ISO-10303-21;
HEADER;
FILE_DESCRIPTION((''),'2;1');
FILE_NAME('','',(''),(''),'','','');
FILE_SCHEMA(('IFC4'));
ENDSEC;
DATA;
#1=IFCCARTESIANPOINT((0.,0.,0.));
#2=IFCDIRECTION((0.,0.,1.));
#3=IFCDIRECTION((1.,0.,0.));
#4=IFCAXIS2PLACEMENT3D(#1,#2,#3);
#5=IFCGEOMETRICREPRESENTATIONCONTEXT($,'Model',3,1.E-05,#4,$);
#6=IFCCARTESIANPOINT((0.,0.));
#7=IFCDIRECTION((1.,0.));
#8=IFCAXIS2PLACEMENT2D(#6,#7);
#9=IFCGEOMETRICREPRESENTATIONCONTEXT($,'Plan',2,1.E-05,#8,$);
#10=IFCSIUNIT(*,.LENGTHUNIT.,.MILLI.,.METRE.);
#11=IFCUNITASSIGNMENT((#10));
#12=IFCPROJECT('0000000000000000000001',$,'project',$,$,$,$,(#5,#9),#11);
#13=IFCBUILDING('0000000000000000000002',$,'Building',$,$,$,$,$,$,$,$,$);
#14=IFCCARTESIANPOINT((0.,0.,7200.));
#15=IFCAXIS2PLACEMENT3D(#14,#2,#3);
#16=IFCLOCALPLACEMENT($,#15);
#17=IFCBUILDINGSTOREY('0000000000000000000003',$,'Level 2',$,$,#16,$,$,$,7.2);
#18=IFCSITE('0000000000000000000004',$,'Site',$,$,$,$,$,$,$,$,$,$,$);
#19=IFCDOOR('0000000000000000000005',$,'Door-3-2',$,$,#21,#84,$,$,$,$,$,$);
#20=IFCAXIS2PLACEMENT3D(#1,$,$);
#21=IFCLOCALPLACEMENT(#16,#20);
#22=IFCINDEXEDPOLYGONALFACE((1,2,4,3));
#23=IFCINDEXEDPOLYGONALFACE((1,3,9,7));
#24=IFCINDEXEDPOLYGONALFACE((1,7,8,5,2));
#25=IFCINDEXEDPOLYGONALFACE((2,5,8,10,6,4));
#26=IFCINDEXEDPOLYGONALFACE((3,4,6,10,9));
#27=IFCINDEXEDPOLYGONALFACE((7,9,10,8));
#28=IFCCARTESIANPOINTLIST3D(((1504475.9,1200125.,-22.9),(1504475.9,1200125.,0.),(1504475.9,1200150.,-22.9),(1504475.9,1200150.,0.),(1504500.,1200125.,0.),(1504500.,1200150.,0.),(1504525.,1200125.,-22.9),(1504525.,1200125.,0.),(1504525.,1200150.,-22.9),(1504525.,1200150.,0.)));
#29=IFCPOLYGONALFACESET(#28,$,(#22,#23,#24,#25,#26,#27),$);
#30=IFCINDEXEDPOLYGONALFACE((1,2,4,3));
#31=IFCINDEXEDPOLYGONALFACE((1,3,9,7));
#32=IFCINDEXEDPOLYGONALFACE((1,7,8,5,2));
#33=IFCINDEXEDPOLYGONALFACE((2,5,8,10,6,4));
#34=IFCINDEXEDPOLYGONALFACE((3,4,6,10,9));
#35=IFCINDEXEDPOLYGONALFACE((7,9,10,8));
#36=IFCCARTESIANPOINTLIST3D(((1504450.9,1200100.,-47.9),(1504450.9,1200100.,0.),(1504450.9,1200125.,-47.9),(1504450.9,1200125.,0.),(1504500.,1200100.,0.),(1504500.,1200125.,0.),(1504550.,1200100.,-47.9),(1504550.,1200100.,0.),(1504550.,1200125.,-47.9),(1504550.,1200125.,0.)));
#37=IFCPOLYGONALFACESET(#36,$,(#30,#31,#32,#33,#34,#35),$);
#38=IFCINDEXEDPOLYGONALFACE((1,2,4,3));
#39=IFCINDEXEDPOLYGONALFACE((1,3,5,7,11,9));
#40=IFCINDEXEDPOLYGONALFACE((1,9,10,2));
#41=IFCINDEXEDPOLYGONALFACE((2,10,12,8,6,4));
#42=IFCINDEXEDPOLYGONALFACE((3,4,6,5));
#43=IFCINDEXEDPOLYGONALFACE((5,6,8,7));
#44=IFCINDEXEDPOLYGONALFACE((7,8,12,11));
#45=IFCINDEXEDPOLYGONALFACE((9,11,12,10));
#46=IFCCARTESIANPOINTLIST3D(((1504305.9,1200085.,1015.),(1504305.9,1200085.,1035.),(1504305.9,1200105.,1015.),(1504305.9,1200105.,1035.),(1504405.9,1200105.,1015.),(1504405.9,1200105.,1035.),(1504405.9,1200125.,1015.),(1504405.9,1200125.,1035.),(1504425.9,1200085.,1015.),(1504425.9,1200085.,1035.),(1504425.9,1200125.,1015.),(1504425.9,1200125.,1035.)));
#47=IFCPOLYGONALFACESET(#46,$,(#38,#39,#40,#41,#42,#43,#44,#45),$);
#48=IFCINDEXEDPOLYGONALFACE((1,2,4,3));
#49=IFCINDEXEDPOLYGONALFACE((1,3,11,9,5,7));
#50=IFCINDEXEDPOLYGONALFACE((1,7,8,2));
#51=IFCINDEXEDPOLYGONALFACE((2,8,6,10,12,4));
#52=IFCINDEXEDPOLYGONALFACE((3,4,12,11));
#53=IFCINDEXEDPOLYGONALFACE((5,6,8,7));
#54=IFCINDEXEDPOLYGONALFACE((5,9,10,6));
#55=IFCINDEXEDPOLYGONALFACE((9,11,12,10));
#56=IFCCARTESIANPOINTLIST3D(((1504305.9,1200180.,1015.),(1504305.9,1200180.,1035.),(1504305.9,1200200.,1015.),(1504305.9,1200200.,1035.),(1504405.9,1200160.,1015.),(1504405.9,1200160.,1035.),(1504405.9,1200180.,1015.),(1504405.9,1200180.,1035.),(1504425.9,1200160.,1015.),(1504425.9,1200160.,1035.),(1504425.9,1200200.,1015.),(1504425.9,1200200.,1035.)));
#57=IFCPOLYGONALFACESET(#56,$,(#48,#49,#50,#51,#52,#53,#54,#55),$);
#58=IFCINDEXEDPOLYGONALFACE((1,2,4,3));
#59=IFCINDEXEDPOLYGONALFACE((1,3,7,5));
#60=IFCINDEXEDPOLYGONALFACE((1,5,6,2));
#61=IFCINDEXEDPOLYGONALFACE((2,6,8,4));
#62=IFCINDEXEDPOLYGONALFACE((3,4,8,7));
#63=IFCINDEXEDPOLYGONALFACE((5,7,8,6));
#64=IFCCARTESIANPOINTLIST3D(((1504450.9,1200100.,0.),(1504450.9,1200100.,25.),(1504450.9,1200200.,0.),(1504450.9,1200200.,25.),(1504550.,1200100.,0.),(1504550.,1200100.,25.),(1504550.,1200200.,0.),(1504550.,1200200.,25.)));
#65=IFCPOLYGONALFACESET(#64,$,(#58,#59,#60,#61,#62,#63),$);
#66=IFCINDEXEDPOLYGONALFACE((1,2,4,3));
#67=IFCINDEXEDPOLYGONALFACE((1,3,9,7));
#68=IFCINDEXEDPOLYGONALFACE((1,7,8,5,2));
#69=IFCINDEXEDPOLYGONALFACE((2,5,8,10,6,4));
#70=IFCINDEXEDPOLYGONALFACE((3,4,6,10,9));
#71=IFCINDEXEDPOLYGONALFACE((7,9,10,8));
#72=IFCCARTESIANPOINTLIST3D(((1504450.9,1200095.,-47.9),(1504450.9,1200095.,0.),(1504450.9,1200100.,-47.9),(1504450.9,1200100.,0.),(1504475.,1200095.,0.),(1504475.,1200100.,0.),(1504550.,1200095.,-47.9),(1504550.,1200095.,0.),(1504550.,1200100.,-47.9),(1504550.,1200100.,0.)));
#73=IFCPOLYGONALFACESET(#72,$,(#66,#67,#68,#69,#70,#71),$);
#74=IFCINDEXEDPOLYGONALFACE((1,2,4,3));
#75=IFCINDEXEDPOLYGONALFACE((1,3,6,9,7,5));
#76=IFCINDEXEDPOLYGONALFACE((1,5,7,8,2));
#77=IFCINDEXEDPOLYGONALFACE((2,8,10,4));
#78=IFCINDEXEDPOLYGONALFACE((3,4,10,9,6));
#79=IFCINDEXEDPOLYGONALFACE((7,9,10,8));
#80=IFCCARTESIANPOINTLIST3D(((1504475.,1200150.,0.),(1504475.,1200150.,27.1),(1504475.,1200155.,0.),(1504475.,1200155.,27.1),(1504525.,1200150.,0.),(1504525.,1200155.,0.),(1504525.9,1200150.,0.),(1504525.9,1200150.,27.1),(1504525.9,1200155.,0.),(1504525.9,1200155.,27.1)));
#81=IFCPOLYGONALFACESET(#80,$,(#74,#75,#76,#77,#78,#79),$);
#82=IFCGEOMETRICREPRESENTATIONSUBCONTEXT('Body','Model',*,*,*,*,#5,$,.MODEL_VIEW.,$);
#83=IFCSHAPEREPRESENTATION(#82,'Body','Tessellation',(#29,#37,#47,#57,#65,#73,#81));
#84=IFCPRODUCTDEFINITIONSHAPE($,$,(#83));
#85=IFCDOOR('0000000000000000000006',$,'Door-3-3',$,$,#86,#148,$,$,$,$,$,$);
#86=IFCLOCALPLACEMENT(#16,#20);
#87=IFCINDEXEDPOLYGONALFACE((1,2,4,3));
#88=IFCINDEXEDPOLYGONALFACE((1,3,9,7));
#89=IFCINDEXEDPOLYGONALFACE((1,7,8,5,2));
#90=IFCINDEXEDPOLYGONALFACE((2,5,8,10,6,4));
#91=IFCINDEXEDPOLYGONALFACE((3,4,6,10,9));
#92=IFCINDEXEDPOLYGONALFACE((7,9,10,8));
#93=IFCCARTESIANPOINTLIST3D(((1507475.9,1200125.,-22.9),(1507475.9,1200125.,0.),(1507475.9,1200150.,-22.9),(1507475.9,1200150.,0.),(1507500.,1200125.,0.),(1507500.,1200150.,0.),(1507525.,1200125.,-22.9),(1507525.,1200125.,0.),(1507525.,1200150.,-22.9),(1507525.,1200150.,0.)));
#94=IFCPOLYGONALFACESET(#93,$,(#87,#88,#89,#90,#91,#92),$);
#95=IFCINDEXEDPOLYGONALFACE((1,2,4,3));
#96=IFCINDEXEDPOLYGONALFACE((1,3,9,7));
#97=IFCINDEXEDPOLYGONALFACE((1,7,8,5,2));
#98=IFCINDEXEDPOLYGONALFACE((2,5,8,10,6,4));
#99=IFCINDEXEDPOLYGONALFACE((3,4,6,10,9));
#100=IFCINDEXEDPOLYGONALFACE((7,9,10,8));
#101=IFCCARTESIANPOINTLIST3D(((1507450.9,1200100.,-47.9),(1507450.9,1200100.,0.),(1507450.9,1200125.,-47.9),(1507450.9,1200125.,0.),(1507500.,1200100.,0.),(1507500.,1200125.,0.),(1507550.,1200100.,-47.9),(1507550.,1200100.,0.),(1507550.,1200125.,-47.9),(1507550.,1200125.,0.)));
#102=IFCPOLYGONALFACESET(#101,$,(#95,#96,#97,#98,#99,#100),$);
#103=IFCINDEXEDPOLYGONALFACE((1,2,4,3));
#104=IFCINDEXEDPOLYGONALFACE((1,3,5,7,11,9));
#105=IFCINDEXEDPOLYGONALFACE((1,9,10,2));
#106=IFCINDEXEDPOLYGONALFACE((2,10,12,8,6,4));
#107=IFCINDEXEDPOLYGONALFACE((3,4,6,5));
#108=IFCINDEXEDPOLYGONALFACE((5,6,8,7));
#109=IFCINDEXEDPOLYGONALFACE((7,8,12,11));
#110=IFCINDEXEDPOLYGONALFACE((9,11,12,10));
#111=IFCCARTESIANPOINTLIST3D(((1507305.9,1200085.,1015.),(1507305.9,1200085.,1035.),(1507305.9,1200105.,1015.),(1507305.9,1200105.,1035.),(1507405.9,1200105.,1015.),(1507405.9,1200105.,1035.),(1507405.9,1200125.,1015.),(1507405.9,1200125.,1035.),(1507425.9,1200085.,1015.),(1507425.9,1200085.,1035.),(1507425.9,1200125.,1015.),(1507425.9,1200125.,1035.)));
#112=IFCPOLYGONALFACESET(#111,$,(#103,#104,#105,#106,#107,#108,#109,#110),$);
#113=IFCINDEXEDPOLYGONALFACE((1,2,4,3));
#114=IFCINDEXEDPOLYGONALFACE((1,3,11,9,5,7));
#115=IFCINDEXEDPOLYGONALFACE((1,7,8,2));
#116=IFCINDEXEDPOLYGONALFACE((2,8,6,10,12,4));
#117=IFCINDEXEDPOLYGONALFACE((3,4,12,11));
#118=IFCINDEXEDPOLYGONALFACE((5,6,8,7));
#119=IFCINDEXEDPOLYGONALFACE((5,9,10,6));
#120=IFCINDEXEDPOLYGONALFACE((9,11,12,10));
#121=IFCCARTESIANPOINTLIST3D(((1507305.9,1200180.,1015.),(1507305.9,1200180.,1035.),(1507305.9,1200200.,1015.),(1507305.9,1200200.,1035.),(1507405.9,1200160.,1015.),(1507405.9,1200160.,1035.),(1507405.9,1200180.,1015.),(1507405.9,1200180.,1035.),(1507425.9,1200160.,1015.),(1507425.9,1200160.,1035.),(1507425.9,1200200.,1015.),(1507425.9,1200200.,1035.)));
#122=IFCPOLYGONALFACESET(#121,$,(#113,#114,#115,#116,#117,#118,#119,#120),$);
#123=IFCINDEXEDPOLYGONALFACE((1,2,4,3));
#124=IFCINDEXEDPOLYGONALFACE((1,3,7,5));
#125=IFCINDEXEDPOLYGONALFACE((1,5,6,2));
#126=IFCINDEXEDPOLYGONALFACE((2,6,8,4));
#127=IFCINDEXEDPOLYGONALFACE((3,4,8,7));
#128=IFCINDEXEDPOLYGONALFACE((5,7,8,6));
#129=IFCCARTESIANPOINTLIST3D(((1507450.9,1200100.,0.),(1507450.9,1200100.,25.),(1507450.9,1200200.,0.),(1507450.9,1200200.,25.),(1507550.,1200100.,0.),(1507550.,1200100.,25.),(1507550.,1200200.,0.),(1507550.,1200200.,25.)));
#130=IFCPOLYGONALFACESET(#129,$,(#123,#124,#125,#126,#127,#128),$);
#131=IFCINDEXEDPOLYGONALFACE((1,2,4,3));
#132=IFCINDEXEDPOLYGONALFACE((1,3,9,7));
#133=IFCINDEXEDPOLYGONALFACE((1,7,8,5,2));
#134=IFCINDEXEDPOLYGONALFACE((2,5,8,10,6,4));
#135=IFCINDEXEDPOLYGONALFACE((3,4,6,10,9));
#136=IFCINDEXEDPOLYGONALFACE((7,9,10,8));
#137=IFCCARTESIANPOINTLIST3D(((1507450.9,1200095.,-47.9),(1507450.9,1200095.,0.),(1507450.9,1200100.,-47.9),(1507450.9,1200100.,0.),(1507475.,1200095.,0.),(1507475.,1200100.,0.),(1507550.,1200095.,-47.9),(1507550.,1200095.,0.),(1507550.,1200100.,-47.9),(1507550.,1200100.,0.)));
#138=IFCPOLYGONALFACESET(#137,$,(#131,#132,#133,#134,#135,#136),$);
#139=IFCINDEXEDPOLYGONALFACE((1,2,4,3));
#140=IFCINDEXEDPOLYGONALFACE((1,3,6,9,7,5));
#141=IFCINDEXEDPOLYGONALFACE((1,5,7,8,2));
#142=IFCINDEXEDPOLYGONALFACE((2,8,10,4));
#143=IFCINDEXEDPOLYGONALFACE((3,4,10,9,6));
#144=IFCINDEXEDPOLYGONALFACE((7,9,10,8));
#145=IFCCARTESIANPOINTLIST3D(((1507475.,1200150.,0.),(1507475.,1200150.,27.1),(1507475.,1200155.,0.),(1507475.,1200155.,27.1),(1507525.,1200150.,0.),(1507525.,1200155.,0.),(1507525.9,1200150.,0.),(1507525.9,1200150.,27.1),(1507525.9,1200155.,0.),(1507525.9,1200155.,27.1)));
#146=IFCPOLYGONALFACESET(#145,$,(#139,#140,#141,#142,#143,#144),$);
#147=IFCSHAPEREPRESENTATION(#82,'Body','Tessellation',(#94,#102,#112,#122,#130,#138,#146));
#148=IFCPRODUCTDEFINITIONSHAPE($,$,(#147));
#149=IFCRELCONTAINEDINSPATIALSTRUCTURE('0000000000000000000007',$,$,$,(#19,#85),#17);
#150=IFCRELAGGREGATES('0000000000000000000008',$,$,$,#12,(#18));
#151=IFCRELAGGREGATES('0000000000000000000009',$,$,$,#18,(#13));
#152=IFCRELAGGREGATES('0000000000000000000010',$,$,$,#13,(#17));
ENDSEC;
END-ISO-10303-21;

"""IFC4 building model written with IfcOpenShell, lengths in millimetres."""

from ifc_helpers import new_model, si_unit, frame, origin_with_axes, origin_2d_with_axis, place, context, subcontext, project, spatial, line, indexed_curve, outline, extrude, element, save


model = new_model("IFC4")

# Units and contexts
model_context = context("Model", 3, precision=1e-05, world=origin_with_axes())
plan_context = context("Plan", 2, precision=1e-05, world=origin_2d_with_axis())
body_context = subcontext(model_context, "Body", "Model", "MODEL_VIEW")
ifc_project = project(units=[si_unit("LENGTHUNIT", "METRE", prefix="MILLI")], contexts=[model_context, plan_context])

# Site, building, storey
site = spatial("IfcSite", under=ifc_project, Name="Site")
building = spatial("IfcBuilding", under=site, Name="Building")
storey_placement = place(None, frame((0.0, 0.0, 7200.0), z_axis=(0.0, 0.0, 1.0), x_axis=(1.0, 0.0, 0.0)))
storey = spatial("IfcBuildingStorey", under=building, at=storey_placement, Name="Level 2", Elevation=7.2)

# Doors
door_1_placement = place(storey_placement, frame((1504500.0, 1200100.0, 0.0), z_axis=(0.0, 0.0, 1.0), x_axis=(1.0, 0.0, 0.0)))
element("IfcDoor", 1, at=door_1_placement, inside=storey, Name="Door-3-2", context=body_context, shape_type="SweptSolid", body=[
    extrude(outline(indexed_curve([(0.0, 0.0), (0.0, 2.1), (0.9, 2.1), (0.9, 0.0), (-24.1, 0.0), (-24.1, -22.9), (25.0, -22.9), (25.0, 0.0)], segments=[line(1, 2, 3, 4, 5, 6, 7, 8, 1)])), frame((0.0, 25.0, 0.0), z_axis=(0.0, -1.0, 0.0), x_axis=(1.0, 0.0, 0.0)), (0.0, 0.0, -1.0), 25.0),
    extrude(outline(indexed_curve([(0.0, 0.0), (0.0, 2.1), (0.9, 2.1), (0.9, 0.0), (-49.1, 0.0), (-49.1, -47.9), (50.0, -47.9), (50.0, 0.0)], segments=[line(1, 2, 3, 4, 5, 6, 7, 8, 1)])), frame((0.0, 0.0, 0.0), z_axis=(0.0, -1.0, 0.0), x_axis=(1.0, 0.0, 0.0)), (0.0, 0.0, -1.0), 25.0),
    extrude(outline(indexed_curve([(0.0, 0.0), (-49.1, 0.0), (-49.1, 35.0), (0.0, 35.0)], segments=[line(1, 2, 3, 4, 1)])), frame((25.0, 25.0, 25.0), z_axis=(0.0, 0.0, 1.0), x_axis=(1.0, 0.0, 0.0)), (0.0, 0.0, 1.0), -47.9),
    extrude(outline(indexed_curve([(0.0, 0.0), (0.0, -40.0), (-120.0, -40.0), (-120.0, -20.0), (-20.0, -20.0), (-20.0, 0.0)], segments=[line(1, 2, 3, 4, 5, 6, 1)])), frame((-74.1, 25.0, 1015.0), z_axis=(0.0, 0.0, 1.0), x_axis=(1.0, 0.0, 0.0)), (0.0, 0.0, 1.0), 20.0),
    extrude(outline(indexed_curve([(0.0, 0.0), (0.0, 40.0), (-120.0, 40.0), (-120.0, 20.0), (-20.0, 20.0), (-20.0, 0.0)], segments=[line(1, 2, 3, 4, 5, 6, 1)])), frame((-74.1, 60.0, 1015.0), z_axis=(0.0, 0.0, 1.0), x_axis=(1.0, 0.0, 0.0)), (0.0, 0.0, 1.0), 20.0),
    extrude(outline(indexed_curve([(0.0, 0.0), (-99.1, 0.0), (-99.1, 100.0), (0.0, 100.0)], segments=[line(1, 2, 3, 4, 1)])), frame((50.0, 0.0, 0.0), z_axis=(0.0, 0.0, 1.0), x_axis=(1.0, 0.0, 0.0)), (0.0, 0.0, 1.0), 25.0),
    extrude(outline(indexed_curve([(0.0, 0.0), (0.0, 27.1), (50.9, 27.1), (50.9, 0.0), (-24.1, 0.0), (-24.1, -47.9), (75.0, -47.9), (75.0, 0.0)], segments=[line(1, 2, 3, 4, 5, 6, 7, 8, 1)])), frame((-25.0, -5.0, 0.0), z_axis=(0.0, -1.0, 0.0), x_axis=(1.0, 0.0, 0.0)), (0.0, 0.0, -1.0), 5.0),
    extrude(outline(indexed_curve([(0.0, 0.0), (0.0, 27.1), (50.9, 27.1), (50.9, 0.0), (0.9, 0.0), (0.9, -22.9), (50.0, -22.9), (50.0, 0.0)], segments=[line(1, 2, 3, 4, 5, 6, 7, 8, 1)])), frame((-25.0, 50.0, 0.0), z_axis=(0.0, -1.0, 0.0), x_axis=(1.0, 0.0, 0.0)), (0.0, 0.0, -1.0), 5.0),
])
door_2_placement = place(storey_placement, frame((1507500.0, 1200100.0, 0.0), z_axis=(0.0, 0.0, 1.0), x_axis=(1.0, 0.0, 0.0)))
element("IfcDoor", 2, at=door_2_placement, inside=storey, Name="Door-3-3", context=body_context, shape_type="SweptSolid", body=[
    extrude(outline(indexed_curve([(0.0, 0.0), (0.0, 2.1), (0.9, 2.1), (0.9, 0.0), (-24.1, 0.0), (-24.1, -22.9), (25.0, -22.9), (25.0, 0.0)], segments=[line(1, 2, 3, 4, 5, 6, 7, 8, 1)])), frame((0.0, 25.0, 0.0), z_axis=(0.0, -1.0, 0.0), x_axis=(1.0, 0.0, 0.0)), (0.0, 0.0, -1.0), 25.0),
    extrude(outline(indexed_curve([(0.0, 0.0), (0.0, 2.1), (0.9, 2.1), (0.9, 0.0), (-49.1, 0.0), (-49.1, -47.9), (50.0, -47.9), (50.0, 0.0)], segments=[line(1, 2, 3, 4, 5, 6, 7, 8, 1)])), frame((0.0, 0.0, 0.0), z_axis=(0.0, -1.0, 0.0), x_axis=(1.0, 0.0, 0.0)), (0.0, 0.0, -1.0), 25.0),
    extrude(outline(indexed_curve([(0.0, 0.0), (-49.1, 0.0), (-49.1, 35.0), (0.0, 35.0)], segments=[line(1, 2, 3, 4, 1)])), frame((25.0, 25.0, 25.0), z_axis=(0.0, 0.0, 1.0), x_axis=(1.0, 0.0, 0.0)), (0.0, 0.0, 1.0), -47.9),
    extrude(outline(indexed_curve([(0.0, 0.0), (0.0, -40.0), (-120.0, -40.0), (-120.0, -20.0), (-20.0, -20.0), (-20.0, 0.0)], segments=[line(1, 2, 3, 4, 5, 6, 1)])), frame((-74.1, 25.0, 1015.0), z_axis=(0.0, 0.0, 1.0), x_axis=(1.0, 0.0, 0.0)), (0.0, 0.0, 1.0), 20.0),
    extrude(outline(indexed_curve([(0.0, 0.0), (0.0, 40.0), (-120.0, 40.0), (-120.0, 20.0), (-20.0, 20.0), (-20.0, 0.0)], segments=[line(1, 2, 3, 4, 5, 6, 1)])), frame((-74.1, 60.0, 1015.0), z_axis=(0.0, 0.0, 1.0), x_axis=(1.0, 0.0, 0.0)), (0.0, 0.0, 1.0), 20.0),
    extrude(outline(indexed_curve([(0.0, 0.0), (-99.1, 0.0), (-99.1, 100.0), (0.0, 100.0)], segments=[line(1, 2, 3, 4, 1)])), frame((50.0, 0.0, 0.0), z_axis=(0.0, 0.0, 1.0), x_axis=(1.0, 0.0, 0.0)), (0.0, 0.0, 1.0), 25.0),
    extrude(outline(indexed_curve([(0.0, 0.0), (0.0, 27.1), (50.9, 27.1), (50.9, 0.0), (-24.1, 0.0), (-24.1, -47.9), (75.0, -47.9), (75.0, 0.0)], segments=[line(1, 2, 3, 4, 5, 6, 7, 8, 1)])), frame((-25.0, -5.0, 0.0), z_axis=(0.0, -1.0, 0.0), x_axis=(1.0, 0.0, 0.0)), (0.0, 0.0, -1.0), 5.0),
    extrude(outline(indexed_curve([(0.0, 0.0), (0.0, 27.1), (50.9, 27.1), (50.9, 0.0), (0.9, 0.0), (0.9, -22.9), (50.0, -22.9), (50.0, 0.0)], segments=[line(1, 2, 3, 4, 5, 6, 7, 8, 1)])), frame((-25.0, 50.0, 0.0), z_axis=(0.0, -1.0, 0.0), x_axis=(1.0, 0.0, 0.0)), (0.0, 0.0, -1.0), 5.0),
])

save(model, "model.ifc")
